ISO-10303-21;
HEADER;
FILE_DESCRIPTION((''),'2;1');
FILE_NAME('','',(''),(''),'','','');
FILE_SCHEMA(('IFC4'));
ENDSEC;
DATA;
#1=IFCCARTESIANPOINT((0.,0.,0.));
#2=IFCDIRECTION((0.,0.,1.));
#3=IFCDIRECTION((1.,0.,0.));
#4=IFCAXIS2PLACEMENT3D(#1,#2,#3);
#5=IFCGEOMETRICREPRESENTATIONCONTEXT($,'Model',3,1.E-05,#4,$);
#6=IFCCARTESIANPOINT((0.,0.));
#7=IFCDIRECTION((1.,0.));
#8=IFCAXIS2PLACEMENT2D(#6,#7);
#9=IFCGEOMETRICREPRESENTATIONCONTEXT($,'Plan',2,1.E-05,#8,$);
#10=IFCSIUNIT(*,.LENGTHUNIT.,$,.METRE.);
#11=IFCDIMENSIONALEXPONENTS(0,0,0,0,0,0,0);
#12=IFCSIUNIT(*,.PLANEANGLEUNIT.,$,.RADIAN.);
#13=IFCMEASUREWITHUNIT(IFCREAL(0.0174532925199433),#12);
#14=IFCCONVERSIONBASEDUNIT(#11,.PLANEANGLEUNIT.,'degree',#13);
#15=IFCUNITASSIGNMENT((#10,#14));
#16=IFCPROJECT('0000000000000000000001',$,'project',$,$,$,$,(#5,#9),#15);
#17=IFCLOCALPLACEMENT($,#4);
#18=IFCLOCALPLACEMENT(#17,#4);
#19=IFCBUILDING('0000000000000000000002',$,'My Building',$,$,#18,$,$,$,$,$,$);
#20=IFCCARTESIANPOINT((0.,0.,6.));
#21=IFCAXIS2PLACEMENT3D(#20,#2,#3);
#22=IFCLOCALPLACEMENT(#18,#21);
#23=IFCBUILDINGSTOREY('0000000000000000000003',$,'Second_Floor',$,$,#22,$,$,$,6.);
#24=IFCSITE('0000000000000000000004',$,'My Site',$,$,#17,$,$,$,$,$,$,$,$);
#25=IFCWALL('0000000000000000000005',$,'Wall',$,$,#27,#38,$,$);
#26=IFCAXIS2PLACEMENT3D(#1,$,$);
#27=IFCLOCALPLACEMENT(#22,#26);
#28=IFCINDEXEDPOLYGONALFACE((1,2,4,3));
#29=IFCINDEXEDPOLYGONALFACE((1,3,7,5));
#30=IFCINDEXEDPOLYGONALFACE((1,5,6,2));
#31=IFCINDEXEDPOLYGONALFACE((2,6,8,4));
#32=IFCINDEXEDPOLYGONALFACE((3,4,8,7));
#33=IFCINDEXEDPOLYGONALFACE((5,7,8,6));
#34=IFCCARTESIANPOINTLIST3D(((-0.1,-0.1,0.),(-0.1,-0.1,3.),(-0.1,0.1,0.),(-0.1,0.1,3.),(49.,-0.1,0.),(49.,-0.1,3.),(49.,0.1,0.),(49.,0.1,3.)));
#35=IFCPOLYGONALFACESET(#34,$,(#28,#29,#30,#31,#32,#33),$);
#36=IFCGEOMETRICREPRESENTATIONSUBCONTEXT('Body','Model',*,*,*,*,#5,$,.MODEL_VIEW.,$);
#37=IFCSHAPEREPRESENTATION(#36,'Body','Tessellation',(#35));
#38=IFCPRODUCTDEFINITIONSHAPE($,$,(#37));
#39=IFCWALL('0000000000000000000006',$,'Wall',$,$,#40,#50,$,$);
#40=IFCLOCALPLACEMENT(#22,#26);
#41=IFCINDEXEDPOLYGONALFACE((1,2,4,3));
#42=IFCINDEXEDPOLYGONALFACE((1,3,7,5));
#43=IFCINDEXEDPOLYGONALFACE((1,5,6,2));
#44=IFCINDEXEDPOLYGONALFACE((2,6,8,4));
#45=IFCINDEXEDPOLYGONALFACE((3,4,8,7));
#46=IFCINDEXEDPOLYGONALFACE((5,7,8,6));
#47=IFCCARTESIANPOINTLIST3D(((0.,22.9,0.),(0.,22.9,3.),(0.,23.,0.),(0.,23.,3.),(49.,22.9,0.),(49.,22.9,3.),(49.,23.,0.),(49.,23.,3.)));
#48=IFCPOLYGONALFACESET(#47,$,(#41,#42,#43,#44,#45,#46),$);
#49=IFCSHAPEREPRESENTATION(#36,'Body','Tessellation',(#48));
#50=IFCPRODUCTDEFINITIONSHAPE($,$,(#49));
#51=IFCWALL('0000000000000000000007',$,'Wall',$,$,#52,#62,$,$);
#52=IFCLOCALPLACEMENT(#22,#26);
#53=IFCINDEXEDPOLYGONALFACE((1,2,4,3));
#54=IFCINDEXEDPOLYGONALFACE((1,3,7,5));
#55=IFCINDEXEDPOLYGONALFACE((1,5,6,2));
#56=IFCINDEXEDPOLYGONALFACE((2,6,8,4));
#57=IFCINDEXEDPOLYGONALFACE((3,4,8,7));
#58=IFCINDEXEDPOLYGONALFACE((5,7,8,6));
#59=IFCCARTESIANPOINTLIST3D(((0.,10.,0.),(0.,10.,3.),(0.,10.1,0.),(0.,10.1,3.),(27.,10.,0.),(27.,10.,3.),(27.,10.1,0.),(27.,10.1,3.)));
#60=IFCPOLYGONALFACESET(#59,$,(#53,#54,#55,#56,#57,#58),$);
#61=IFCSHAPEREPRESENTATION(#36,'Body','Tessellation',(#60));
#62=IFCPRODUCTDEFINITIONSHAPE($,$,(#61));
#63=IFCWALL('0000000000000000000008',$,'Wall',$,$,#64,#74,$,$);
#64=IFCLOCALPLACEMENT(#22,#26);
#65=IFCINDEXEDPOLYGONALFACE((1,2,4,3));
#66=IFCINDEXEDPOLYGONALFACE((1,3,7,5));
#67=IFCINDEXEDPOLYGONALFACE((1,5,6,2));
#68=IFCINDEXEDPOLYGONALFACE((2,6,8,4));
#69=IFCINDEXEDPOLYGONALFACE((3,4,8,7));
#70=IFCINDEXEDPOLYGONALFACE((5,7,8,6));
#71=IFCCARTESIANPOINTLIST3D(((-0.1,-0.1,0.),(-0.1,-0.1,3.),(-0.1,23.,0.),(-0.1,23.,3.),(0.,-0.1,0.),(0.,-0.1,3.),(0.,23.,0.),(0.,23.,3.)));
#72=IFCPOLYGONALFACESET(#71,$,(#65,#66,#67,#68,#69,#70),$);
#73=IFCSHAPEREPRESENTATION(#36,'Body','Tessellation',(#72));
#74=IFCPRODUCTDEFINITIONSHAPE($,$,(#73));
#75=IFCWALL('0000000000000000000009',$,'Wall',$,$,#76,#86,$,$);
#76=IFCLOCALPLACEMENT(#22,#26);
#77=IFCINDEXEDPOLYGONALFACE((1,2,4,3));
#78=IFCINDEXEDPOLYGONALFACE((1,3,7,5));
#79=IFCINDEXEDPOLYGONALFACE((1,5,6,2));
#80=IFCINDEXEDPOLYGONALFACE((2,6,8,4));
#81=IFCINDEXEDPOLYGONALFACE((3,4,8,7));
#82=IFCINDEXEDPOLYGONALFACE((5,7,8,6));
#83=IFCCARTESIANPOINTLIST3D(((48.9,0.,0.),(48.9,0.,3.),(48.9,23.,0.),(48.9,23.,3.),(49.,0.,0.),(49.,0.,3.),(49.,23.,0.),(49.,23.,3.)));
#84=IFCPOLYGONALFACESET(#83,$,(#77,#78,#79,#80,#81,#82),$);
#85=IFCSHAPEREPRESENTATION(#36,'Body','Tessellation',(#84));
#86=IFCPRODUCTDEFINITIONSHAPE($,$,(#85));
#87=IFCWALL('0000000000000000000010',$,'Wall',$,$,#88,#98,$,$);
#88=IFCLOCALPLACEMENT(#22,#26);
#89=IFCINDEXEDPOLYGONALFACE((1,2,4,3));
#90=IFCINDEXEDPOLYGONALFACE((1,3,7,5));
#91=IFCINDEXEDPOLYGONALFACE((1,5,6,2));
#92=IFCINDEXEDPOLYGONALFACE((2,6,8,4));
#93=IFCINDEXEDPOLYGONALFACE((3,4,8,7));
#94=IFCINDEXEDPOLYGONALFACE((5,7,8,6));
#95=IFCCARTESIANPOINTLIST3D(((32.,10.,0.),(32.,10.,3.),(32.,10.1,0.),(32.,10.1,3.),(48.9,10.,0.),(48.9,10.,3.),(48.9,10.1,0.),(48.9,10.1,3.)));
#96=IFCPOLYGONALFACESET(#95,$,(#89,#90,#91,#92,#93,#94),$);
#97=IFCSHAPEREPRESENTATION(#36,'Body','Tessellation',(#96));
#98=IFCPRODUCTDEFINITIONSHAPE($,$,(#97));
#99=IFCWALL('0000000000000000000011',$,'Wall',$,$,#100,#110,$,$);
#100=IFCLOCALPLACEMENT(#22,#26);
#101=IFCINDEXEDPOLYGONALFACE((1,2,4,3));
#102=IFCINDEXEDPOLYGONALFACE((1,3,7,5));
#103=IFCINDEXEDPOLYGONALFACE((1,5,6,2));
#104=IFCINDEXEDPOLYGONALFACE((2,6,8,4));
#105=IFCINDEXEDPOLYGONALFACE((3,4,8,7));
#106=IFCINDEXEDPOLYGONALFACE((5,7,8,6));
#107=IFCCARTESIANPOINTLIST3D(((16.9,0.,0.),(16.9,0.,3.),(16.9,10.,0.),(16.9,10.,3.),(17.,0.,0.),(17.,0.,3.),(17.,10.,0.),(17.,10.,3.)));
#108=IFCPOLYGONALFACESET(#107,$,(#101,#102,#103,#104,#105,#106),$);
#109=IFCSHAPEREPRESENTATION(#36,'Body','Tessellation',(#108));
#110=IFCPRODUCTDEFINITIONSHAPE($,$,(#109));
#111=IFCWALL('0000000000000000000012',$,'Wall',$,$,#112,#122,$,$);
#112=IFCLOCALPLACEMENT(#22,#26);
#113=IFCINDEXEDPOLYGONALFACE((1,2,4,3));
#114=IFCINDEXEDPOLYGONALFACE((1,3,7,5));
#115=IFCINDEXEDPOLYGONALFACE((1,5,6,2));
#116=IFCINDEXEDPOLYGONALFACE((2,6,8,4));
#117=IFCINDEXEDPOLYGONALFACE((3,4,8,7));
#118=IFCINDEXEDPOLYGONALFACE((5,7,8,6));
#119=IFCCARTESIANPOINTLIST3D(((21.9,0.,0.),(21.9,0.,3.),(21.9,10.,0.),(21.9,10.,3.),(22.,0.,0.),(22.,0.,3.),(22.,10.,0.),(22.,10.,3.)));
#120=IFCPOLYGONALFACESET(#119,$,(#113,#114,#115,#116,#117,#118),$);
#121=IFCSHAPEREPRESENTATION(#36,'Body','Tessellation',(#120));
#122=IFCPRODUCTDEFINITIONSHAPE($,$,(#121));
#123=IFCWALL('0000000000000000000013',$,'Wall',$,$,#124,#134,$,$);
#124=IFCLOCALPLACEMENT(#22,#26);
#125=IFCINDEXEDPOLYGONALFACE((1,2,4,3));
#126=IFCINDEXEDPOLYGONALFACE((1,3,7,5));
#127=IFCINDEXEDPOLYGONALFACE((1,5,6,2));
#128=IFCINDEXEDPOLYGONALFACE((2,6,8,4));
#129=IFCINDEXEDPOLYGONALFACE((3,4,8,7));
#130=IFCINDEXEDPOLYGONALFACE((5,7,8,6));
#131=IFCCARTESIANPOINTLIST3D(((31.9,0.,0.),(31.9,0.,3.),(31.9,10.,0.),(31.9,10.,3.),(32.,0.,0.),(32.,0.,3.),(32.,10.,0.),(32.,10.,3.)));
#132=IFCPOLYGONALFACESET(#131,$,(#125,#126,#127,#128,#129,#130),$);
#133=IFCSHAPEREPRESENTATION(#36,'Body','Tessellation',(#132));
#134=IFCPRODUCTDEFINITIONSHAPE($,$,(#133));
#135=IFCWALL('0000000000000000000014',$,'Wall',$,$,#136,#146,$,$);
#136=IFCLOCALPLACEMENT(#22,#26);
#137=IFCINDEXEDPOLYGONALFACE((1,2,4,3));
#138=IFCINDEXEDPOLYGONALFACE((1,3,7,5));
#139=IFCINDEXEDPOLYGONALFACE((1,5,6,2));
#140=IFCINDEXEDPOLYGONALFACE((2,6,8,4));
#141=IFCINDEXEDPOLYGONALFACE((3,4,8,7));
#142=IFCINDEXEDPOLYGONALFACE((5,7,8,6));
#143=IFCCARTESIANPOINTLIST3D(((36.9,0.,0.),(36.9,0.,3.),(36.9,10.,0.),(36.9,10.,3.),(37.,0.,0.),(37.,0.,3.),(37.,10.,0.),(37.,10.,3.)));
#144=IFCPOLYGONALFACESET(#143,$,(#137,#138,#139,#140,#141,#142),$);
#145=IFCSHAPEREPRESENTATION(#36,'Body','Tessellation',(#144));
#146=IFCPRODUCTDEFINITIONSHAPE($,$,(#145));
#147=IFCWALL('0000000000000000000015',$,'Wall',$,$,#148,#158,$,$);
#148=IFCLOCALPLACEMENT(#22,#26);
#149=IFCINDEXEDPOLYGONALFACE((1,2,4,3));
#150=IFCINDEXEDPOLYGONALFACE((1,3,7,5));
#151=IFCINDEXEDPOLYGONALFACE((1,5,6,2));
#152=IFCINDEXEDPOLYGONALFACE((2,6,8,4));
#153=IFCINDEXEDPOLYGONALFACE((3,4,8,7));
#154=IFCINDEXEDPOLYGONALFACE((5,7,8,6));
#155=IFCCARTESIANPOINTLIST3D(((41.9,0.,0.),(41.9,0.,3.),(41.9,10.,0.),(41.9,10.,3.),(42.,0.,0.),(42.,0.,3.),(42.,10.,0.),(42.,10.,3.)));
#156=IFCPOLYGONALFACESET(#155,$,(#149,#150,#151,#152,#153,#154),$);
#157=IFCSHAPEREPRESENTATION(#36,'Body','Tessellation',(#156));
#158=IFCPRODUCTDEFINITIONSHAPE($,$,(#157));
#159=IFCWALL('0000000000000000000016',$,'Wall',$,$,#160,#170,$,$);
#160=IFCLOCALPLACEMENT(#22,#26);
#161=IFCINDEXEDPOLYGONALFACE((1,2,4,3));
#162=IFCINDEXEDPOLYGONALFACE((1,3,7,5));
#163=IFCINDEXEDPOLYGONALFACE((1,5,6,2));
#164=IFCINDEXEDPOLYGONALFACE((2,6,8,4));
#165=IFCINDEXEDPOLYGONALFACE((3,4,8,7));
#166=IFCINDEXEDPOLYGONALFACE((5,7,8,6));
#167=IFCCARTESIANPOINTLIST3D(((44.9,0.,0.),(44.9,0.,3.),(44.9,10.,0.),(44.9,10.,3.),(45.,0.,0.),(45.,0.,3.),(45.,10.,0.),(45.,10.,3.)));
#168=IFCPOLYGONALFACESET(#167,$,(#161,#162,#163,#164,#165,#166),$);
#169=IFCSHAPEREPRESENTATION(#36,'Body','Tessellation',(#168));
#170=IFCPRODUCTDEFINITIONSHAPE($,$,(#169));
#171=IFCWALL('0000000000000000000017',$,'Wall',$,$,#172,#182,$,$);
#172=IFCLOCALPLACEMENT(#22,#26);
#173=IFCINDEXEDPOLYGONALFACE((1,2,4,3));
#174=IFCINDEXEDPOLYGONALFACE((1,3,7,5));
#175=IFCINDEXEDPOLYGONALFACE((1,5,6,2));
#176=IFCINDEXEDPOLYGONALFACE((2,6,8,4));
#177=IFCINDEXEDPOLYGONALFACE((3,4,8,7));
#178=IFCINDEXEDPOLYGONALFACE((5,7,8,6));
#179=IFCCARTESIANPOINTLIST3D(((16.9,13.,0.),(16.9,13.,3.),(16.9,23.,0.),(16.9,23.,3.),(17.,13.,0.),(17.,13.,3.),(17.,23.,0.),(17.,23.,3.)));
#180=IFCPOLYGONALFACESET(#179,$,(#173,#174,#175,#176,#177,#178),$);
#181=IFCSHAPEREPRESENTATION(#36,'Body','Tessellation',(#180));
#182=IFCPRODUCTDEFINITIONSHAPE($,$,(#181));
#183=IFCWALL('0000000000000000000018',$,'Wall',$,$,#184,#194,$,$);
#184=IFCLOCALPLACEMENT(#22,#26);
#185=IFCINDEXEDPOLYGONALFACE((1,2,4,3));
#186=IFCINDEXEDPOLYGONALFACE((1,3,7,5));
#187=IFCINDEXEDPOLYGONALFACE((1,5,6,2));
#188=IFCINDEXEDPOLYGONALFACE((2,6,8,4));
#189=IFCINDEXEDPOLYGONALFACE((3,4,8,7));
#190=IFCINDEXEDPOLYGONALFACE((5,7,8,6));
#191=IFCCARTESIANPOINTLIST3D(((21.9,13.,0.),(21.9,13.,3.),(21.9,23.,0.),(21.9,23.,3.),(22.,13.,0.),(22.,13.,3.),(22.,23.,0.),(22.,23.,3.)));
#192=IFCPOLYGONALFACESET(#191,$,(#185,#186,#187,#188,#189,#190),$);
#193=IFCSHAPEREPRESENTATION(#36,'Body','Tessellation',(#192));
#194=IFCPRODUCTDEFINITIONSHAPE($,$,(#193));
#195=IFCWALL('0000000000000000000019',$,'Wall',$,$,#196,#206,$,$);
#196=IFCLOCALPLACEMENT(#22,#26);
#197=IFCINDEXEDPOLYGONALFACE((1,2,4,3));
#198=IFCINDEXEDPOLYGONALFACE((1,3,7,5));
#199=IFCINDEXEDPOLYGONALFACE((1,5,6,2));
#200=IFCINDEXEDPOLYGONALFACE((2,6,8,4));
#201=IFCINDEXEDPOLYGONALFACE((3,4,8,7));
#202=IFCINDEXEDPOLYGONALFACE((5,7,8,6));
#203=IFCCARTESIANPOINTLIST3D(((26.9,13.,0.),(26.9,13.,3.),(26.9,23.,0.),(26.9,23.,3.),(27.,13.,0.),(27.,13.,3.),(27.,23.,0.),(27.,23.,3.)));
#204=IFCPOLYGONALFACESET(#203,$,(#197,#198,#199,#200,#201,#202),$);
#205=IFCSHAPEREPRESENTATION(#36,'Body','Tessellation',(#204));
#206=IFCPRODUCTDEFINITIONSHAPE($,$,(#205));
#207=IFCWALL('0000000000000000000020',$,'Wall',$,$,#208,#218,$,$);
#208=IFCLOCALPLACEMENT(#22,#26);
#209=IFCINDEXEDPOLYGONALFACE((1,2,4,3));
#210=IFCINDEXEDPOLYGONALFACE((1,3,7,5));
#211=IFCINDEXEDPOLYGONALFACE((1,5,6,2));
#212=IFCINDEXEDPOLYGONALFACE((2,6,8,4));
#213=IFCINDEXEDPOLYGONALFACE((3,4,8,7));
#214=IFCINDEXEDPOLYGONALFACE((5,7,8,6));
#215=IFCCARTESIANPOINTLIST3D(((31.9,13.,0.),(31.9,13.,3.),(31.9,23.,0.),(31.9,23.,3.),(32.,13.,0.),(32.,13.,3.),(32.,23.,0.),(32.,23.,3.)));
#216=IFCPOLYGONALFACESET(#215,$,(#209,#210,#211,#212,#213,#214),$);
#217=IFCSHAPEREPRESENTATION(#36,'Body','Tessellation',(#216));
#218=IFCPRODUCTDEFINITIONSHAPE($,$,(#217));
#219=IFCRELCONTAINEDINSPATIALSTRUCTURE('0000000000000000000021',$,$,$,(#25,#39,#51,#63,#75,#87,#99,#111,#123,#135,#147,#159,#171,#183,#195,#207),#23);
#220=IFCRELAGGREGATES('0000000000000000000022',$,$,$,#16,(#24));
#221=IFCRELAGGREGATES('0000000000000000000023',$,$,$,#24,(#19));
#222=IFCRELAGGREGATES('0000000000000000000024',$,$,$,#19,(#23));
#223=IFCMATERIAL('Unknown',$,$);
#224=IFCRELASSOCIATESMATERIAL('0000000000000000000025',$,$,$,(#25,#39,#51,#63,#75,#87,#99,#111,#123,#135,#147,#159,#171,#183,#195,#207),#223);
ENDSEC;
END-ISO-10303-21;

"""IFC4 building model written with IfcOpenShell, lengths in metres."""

from ifc_helpers import new_model, entity, si_unit, converted_unit, frame, frame_2d, origin, origin_with_axes, origin_2d_with_axis, place, context, subcontext, project, spatial, rectangle, extrude, material, element, save


model = new_model("IFC4")

# Units and contexts
model_context = context("Model", 3, precision=1e-05, world=origin_with_axes())
plan_context = context("Plan", 2, precision=1e-05, world=origin_2d_with_axis())
body_context = subcontext(model_context, "Body", "Model", "MODEL_VIEW")
ifc_project = project(units=[si_unit("LENGTHUNIT", "METRE"), converted_unit("PLANEANGLEUNIT", "degree", entity("IfcReal", 0.0174532925199433), si_unit("PLANEANGLEUNIT", "RADIAN"), dimensions=[0, 0, 0, 0, 0, 0, 0])], contexts=[model_context, plan_context])

# Site, building, storey
site_placement = place(None, origin_with_axes())
site = spatial("IfcSite", under=ifc_project, at=site_placement, Name="My Site")
building_placement = place(site_placement, origin_with_axes())
building = spatial("IfcBuilding", under=site, at=building_placement, Name="My Building")
storey_placement = place(building_placement, frame((0.0, 0.0, 6.0), z_axis=(0.0, 0.0, 1.0), x_axis=(1.0, 0.0, 0.0)))
storey = spatial("IfcBuildingStorey", under=building, at=storey_placement, Name="Second_Floor", Elevation=6.0)

# Walls
ifc_material = material(Name="Unknown")
wall_1_placement = place(storey_placement, origin_with_axes())
element("IfcWall", 1, at=wall_1_placement, inside=storey, material=ifc_material, Name="Wall", context=body_context, shape_type="SweptSolid", body=[
    extrude(rectangle(XDim=49.1, YDim=0.2, at=frame_2d((24.45, 0.0))), origin(), (0.0, 0.0, 1.0), 3.0),
])
wall_2_placement = place(storey_placement, origin_with_axes())
element("IfcWall", 2, at=wall_2_placement, inside=storey, material=ifc_material, Name="Wall", context=body_context, shape_type="SweptSolid", body=[
    extrude(rectangle(XDim=49.0, YDim=0.1, at=frame_2d((24.5, 22.95))), origin(), (0.0, 0.0, 1.0), 3.0),
])
wall_3_placement = place(storey_placement, origin_with_axes())
element("IfcWall", 3, at=wall_3_placement, inside=storey, material=ifc_material, Name="Wall", context=body_context, shape_type="SweptSolid", body=[
    extrude(rectangle(XDim=27.0, YDim=0.1, at=frame_2d((13.5, 10.05))), origin(), (0.0, 0.0, 1.0), 3.0),
])
wall_4_placement = place(storey_placement, origin_with_axes())
element("IfcWall", 4, at=wall_4_placement, inside=storey, material=ifc_material, Name="Wall", context=body_context, shape_type="SweptSolid", body=[
    extrude(rectangle(XDim=0.1, YDim=23.1, at=frame_2d((-0.05, 11.45))), origin(), (0.0, 0.0, 1.0), 3.0),
])
wall_5_placement = place(storey_placement, origin_with_axes())
element("IfcWall", 5, at=wall_5_placement, inside=storey, material=ifc_material, Name="Wall", context=body_context, shape_type="SweptSolid", body=[
    extrude(rectangle(XDim=0.1, YDim=23.0, at=frame_2d((48.95, 11.5))), origin(), (0.0, 0.0, 1.0), 3.0),
])
wall_6_placement = place(storey_placement, origin_with_axes())
element("IfcWall", 6, at=wall_6_placement, inside=storey, material=ifc_material, Name="Wall", context=body_context, shape_type="SweptSolid", body=[
    extrude(rectangle(XDim=16.9, YDim=0.1, at=frame_2d((40.45, 10.05))), origin(), (0.0, 0.0, 1.0), 3.0),
])
wall_7_placement = place(storey_placement, origin_with_axes())
element("IfcWall", 7, at=wall_7_placement, inside=storey, material=ifc_material, Name="Wall", context=body_context, shape_type="SweptSolid", body=[
    extrude(rectangle(XDim=0.1, YDim=10.0, at=frame_2d((16.95, 5.0))), origin(), (0.0, 0.0, 1.0), 3.0),
])
wall_8_placement = place(storey_placement, origin_with_axes())
element("IfcWall", 8, at=wall_8_placement, inside=storey, material=ifc_material, Name="Wall", context=body_context, shape_type="SweptSolid", body=[
    extrude(rectangle(XDim=0.1, YDim=10.0, at=frame_2d((21.95, 5.0))), origin(), (0.0, 0.0, 1.0), 3.0),
])
wall_9_placement = place(storey_placement, origin_with_axes())
element("IfcWall", 9, at=wall_9_placement, inside=storey, material=ifc_material, Name="Wall", context=body_context, shape_type="SweptSolid", body=[
    extrude(rectangle(XDim=0.1, YDim=10.0, at=frame_2d((31.95, 5.0))), origin(), (0.0, 0.0, 1.0), 3.0),
])
wall_10_placement = place(storey_placement, origin_with_axes())
element("IfcWall", 10, at=wall_10_placement, inside=storey, material=ifc_material, Name="Wall", context=body_context, shape_type="SweptSolid", body=[
    extrude(rectangle(XDim=0.1, YDim=10.0, at=frame_2d((36.95, 5.0))), origin(), (0.0, 0.0, 1.0), 3.0),
])
wall_11_placement = place(storey_placement, origin_with_axes())
element("IfcWall", 11, at=wall_11_placement, inside=storey, material=ifc_material, Name="Wall", context=body_context, shape_type="SweptSolid", body=[
    extrude(rectangle(XDim=0.1, YDim=10.0, at=frame_2d((41.95, 5.0))), origin(), (0.0, 0.0, 1.0), 3.0),
])
wall_12_placement = place(storey_placement, origin_with_axes())
element("IfcWall", 12, at=wall_12_placement, inside=storey, material=ifc_material, Name="Wall", context=body_context, shape_type="SweptSolid", body=[
    extrude(rectangle(XDim=0.1, YDim=10.0, at=frame_2d((44.95, 5.0))), origin(), (0.0, 0.0, 1.0), 3.0),
])
wall_13_placement = place(storey_placement, origin_with_axes())
element("IfcWall", 13, at=wall_13_placement, inside=storey, material=ifc_material, Name="Wall", context=body_context, shape_type="SweptSolid", body=[
    extrude(rectangle(XDim=0.1, YDim=10.0, at=frame_2d((16.95, 18.0))), origin(), (0.0, 0.0, 1.0), 3.0),
])
wall_14_placement = place(storey_placement, origin_with_axes())
element("IfcWall", 14, at=wall_14_placement, inside=storey, material=ifc_material, Name="Wall", context=body_context, shape_type="SweptSolid", body=[
    extrude(rectangle(XDim=0.1, YDim=10.0, at=frame_2d((21.95, 18.0))), origin(), (0.0, 0.0, 1.0), 3.0),
])
wall_15_placement = place(storey_placement, origin_with_axes())
element("IfcWall", 15, at=wall_15_placement, inside=storey, material=ifc_material, Name="Wall", context=body_context, shape_type="SweptSolid", body=[
    extrude(rectangle(XDim=0.1, YDim=10.0, at=frame_2d((26.95, 18.0))), origin(), (0.0, 0.0, 1.0), 3.0),
])
wall_16_placement = place(storey_placement, origin_with_axes())
element("IfcWall", 16, at=wall_16_placement, inside=storey, material=ifc_material, Name="Wall", context=body_context, shape_type="SweptSolid", body=[
    extrude(rectangle(XDim=0.1, YDim=10.0, at=frame_2d((31.95, 18.0))), origin(), (0.0, 0.0, 1.0), 3.0),
])

save(model, "model.ifc")
